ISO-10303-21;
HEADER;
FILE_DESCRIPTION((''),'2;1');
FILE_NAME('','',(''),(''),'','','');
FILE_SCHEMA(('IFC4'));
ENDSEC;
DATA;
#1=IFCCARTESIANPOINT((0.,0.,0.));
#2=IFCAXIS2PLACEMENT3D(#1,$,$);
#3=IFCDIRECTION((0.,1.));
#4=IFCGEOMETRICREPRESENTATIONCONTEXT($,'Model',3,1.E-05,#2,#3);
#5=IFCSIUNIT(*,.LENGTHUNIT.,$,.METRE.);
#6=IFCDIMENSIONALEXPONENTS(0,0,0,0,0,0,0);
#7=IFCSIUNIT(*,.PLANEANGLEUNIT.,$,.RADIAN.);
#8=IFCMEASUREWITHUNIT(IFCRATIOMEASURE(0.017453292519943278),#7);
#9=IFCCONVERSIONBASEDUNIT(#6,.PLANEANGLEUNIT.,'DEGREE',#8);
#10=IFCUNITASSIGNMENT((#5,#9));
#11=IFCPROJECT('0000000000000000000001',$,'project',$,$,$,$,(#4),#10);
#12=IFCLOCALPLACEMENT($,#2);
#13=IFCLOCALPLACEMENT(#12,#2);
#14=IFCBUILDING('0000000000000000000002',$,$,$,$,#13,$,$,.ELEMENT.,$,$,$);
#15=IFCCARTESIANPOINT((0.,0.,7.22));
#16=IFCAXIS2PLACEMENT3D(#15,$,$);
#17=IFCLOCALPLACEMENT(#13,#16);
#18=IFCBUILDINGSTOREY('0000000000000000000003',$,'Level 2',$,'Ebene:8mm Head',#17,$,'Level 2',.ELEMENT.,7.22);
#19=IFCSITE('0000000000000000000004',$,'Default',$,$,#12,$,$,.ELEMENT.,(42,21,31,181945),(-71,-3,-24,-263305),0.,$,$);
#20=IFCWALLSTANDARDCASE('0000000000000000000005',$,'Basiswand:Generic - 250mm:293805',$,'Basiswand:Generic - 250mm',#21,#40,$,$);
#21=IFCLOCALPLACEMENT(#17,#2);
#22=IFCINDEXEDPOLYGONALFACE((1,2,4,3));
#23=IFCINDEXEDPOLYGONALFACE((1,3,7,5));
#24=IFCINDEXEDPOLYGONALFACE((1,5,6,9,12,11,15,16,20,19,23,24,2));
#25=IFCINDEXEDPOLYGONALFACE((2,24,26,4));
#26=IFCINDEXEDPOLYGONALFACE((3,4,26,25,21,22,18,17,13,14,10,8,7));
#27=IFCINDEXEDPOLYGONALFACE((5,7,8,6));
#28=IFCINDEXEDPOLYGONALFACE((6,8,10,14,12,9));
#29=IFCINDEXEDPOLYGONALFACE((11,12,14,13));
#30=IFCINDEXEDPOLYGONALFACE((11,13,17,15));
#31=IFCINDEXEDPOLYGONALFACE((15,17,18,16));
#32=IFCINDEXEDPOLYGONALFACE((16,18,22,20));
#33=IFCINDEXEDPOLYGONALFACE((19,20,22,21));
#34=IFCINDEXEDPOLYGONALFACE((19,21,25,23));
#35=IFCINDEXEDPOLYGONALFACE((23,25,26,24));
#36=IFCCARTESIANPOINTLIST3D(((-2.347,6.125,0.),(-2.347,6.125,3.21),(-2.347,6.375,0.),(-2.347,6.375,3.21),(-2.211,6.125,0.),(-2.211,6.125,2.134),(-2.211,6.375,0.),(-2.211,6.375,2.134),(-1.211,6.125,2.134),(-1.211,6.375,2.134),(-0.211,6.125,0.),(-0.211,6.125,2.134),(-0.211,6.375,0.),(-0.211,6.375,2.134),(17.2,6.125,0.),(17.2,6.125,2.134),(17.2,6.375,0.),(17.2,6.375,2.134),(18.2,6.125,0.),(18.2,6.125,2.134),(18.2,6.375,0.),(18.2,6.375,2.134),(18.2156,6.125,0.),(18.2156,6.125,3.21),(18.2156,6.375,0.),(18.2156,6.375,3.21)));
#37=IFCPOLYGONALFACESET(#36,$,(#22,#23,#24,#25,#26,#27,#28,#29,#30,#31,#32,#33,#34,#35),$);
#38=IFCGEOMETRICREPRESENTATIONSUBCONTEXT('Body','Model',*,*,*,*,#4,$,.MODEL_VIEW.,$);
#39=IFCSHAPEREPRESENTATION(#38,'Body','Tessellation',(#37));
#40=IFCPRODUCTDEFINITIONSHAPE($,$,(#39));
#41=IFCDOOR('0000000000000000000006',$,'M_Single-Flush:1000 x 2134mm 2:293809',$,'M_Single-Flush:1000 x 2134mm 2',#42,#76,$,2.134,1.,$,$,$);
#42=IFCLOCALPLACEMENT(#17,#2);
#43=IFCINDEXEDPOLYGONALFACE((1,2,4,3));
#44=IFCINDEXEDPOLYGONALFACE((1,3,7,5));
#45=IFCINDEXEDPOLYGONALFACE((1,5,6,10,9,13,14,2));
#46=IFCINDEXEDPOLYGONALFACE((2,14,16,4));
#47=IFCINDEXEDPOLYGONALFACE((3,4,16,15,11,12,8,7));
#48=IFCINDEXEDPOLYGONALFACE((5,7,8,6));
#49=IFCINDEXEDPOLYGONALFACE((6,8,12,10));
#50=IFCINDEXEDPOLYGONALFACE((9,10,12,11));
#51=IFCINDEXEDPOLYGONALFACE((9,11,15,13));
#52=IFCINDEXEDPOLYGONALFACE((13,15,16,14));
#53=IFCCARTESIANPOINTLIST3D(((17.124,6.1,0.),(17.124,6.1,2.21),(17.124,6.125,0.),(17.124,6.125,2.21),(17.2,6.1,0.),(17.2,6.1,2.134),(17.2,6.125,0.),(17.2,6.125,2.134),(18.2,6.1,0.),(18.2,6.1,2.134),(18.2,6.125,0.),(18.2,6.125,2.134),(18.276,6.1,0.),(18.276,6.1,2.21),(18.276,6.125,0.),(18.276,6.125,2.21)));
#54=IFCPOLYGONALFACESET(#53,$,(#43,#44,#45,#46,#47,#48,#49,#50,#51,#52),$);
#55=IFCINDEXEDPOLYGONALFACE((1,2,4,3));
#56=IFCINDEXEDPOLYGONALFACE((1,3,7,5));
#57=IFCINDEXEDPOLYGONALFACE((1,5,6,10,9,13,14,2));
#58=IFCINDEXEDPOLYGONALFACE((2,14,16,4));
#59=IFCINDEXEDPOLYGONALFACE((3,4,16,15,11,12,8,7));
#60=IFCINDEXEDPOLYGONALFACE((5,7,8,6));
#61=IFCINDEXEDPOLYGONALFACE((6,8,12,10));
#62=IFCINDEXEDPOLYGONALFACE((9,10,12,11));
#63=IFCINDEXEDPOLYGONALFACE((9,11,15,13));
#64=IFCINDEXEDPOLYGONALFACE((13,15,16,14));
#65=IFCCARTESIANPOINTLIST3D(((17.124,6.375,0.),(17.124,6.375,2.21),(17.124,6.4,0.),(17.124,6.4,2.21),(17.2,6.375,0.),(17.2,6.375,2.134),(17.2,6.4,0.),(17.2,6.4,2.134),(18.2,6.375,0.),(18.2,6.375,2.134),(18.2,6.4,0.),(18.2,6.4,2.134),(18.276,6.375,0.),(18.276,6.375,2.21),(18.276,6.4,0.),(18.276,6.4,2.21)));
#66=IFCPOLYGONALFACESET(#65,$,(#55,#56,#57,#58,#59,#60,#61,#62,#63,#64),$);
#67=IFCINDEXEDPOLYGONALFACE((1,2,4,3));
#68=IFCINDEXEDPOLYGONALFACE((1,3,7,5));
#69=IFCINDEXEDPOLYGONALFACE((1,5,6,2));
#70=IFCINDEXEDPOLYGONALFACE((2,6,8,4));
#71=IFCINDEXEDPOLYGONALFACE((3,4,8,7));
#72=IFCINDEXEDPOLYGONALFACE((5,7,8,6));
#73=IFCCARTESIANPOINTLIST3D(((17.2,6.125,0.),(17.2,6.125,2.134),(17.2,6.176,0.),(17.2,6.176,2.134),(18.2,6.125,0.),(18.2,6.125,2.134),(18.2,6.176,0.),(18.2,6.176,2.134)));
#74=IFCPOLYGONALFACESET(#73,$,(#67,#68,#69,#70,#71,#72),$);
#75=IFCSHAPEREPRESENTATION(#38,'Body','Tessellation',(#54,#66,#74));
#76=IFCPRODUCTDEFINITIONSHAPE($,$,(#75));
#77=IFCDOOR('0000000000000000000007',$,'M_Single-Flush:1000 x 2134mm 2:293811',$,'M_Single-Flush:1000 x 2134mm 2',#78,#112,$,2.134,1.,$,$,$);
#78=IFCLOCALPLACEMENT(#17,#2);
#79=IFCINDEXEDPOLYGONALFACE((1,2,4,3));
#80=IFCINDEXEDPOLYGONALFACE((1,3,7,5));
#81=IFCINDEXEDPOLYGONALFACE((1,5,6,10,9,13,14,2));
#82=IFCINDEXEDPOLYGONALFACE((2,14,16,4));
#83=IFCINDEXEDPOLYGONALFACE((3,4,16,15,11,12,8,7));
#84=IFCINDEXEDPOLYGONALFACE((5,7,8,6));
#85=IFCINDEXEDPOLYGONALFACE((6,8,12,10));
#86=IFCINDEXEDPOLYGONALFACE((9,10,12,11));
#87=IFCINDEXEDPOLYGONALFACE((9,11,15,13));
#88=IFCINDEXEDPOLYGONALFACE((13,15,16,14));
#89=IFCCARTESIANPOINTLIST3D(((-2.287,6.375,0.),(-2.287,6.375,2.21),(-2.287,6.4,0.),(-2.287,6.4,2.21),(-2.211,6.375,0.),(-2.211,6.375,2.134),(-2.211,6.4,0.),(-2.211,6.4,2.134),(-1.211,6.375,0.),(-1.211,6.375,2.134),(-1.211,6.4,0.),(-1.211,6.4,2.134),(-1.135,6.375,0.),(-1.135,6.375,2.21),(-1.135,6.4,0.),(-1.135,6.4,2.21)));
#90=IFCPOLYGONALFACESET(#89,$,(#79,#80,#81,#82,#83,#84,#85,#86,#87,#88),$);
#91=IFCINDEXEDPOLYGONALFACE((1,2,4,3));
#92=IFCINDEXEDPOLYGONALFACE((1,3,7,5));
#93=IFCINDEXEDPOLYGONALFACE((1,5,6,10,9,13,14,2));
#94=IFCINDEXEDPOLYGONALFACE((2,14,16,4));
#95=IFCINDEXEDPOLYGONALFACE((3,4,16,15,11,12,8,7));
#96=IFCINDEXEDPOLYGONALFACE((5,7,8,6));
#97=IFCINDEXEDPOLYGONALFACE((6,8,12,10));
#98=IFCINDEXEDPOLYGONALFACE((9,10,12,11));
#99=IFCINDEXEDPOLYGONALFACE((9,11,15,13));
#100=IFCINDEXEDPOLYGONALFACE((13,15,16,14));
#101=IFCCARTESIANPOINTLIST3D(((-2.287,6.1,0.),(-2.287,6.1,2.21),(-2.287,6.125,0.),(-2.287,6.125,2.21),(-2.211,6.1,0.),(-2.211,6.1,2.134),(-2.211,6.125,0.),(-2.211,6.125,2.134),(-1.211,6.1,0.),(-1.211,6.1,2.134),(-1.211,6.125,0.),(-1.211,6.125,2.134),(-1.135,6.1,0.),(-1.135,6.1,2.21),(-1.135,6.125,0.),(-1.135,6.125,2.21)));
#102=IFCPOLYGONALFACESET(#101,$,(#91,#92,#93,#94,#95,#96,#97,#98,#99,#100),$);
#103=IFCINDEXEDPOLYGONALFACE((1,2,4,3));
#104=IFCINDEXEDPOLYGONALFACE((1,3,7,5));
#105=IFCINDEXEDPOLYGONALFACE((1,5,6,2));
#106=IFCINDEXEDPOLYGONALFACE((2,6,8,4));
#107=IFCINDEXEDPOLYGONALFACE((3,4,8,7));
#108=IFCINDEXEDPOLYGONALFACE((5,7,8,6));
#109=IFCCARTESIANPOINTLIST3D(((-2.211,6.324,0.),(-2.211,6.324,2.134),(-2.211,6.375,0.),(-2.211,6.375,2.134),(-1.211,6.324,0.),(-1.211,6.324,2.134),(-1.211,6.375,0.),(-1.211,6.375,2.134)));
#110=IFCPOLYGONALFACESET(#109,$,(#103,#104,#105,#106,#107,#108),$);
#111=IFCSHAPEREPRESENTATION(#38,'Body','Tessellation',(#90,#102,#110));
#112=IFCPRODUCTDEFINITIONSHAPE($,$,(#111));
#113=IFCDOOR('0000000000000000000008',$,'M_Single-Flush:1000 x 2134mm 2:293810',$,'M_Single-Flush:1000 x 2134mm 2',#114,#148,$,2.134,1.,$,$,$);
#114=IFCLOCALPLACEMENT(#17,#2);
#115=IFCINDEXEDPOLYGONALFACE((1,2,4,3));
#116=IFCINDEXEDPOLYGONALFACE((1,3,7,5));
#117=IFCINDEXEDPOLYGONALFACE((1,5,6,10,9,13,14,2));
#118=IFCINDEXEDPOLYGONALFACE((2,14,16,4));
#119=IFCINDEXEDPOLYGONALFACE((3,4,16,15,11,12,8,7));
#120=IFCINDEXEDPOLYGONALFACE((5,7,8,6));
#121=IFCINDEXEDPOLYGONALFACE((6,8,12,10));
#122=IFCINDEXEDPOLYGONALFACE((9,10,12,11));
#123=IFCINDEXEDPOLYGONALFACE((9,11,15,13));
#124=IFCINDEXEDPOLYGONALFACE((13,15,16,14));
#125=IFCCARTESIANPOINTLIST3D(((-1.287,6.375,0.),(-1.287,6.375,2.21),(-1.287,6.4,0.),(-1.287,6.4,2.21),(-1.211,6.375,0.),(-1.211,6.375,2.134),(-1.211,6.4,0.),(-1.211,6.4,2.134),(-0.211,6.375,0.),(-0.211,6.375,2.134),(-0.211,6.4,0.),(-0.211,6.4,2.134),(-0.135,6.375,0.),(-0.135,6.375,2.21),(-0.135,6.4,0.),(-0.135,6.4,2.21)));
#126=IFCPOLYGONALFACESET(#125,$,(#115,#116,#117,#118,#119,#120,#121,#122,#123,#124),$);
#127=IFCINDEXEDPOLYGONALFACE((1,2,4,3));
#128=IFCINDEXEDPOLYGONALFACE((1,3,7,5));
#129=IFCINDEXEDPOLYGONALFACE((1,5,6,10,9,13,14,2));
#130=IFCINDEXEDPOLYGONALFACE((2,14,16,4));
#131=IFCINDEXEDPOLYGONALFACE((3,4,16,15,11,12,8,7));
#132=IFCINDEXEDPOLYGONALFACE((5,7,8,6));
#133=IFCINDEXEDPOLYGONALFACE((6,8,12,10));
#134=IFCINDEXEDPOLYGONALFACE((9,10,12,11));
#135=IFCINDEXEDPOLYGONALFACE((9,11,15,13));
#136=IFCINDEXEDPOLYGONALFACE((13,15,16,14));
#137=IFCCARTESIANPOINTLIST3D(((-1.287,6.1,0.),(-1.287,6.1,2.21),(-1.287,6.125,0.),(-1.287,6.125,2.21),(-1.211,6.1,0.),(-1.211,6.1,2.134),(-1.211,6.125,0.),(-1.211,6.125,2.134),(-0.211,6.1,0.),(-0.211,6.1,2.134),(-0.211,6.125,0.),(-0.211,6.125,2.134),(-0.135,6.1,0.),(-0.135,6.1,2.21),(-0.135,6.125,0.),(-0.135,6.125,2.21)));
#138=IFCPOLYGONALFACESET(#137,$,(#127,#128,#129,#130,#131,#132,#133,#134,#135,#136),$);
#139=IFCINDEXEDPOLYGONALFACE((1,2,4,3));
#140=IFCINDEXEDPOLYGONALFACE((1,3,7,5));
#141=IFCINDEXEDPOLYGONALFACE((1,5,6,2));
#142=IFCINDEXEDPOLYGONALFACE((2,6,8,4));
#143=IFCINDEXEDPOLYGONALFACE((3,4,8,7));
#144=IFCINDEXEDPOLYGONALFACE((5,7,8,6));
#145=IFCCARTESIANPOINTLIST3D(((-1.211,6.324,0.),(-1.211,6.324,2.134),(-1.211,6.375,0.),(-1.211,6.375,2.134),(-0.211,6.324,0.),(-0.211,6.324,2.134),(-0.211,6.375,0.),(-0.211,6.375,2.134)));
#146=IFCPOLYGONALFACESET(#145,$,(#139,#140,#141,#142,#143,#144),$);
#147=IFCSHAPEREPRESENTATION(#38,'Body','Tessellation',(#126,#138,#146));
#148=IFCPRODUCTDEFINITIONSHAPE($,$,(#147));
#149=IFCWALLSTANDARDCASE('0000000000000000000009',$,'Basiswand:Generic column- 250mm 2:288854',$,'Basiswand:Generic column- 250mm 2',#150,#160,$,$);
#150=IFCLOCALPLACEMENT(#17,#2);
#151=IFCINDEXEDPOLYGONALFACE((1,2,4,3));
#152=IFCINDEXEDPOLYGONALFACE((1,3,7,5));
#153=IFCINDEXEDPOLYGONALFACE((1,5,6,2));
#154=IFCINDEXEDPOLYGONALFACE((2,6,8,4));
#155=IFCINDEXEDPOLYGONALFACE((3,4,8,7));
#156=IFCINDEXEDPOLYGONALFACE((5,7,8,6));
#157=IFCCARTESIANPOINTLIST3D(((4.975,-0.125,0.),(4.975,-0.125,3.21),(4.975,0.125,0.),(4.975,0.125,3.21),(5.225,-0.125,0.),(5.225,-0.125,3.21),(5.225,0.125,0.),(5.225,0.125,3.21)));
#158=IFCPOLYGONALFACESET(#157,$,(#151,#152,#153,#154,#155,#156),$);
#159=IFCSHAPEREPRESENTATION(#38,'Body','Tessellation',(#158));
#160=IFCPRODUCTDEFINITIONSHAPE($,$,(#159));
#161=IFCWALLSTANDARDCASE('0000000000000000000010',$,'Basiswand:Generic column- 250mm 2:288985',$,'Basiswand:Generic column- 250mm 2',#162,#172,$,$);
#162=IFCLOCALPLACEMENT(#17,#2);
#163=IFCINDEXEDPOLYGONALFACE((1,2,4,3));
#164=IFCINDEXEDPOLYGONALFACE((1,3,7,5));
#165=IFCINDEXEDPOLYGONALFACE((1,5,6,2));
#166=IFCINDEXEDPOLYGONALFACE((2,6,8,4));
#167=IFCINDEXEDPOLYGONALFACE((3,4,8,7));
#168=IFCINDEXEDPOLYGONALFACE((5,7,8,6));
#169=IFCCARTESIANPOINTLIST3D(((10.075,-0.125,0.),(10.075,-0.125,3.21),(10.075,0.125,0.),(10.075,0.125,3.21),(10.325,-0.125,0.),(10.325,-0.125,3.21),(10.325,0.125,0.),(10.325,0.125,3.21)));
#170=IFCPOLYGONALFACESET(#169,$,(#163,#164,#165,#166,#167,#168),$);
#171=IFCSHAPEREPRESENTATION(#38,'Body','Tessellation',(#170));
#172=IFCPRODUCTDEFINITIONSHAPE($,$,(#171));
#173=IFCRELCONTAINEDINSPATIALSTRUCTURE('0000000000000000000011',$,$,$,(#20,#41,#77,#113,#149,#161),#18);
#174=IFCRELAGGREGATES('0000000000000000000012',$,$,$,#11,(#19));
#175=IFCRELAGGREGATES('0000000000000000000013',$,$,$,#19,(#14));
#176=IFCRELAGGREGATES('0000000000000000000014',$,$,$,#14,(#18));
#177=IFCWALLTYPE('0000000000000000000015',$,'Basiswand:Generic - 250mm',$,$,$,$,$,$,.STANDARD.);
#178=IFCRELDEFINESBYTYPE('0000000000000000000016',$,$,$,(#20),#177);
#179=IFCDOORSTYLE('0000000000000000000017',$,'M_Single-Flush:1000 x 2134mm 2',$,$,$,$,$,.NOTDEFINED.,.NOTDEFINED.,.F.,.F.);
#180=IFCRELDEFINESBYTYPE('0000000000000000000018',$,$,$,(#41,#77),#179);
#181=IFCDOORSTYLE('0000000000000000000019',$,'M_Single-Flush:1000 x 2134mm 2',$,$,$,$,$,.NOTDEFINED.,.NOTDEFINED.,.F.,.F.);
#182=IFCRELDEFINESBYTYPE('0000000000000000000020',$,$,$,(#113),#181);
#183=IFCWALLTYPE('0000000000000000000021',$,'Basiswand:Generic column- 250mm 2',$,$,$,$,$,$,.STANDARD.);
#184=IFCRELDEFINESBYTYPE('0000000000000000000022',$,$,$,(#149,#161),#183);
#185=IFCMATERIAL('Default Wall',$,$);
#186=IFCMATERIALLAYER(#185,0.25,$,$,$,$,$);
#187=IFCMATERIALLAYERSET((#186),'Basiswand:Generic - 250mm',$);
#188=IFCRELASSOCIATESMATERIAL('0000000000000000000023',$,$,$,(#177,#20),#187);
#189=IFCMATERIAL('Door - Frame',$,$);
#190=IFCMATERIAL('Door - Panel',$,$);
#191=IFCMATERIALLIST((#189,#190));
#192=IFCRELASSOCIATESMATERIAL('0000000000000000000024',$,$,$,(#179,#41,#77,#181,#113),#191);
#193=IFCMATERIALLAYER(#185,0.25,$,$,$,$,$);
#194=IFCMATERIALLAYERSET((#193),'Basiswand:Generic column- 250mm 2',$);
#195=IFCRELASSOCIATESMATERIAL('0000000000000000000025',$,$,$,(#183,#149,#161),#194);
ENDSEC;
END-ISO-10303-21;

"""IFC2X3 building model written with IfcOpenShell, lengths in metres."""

from ifc_helpers import new_model, entity, si_unit, converted_unit, direction, frame, frame_2d, origin, place, context, subcontext, project, spatial, polyline, rectangle, outline, extrude, clip, bounded_halfspace, source, transform, mapped, material, material_list, layer, layer_set, layer_usage, type_object, type_shapes, element, fill, save


model = new_model("IFC2X3")

# Units and contexts
model_context = context("Model", 3, precision=1e-05, world=origin(), true_north=direction((0.0, 1.0)))
body_context = subcontext(model_context, "Body", "Model", "MODEL_VIEW")
ifc_project = project(units=[si_unit("LENGTHUNIT", "METRE"), converted_unit("PLANEANGLEUNIT", "DEGREE", entity("IfcRatioMeasure", 0.017453292519943278), si_unit("PLANEANGLEUNIT", "RADIAN"), dimensions=[0, 0, 0, 0, 0, 0, 0])], contexts=[model_context])

# Site, building, storey
site_placement = place(None, origin())
site = spatial("IfcSite", under=ifc_project, at=site_placement, Name="Default", CompositionType="ELEMENT", RefLatitude=(42, 21, 31, 181945), RefLongitude=(-71, -3, -24, -263305), RefElevation=0.0)
building_placement = place(site_placement, origin())
building = spatial("IfcBuilding", under=site, at=building_placement, CompositionType="ELEMENT")
storey_placement = place(building_placement, frame((0.0, 0.0, 7.22)))
storey = spatial("IfcBuildingStorey", under=building, at=storey_placement, Name="Level 2", ObjectType="Ebene:8mm Head", LongName="Level 2", CompositionType="ELEMENT", Elevation=7.22)

# Shared definitions
ifc_material_1 = material(Name="Default Wall")
ifc_layer_1 = layer(ifc_material_1, 0.25)
ifc_layer_set_1 = layer_set([ifc_layer_1], Name="Basiswand:Generic - 250mm")
ifc_layer_usage_1 = layer_usage(ifc_layer_set_1, "AXIS2", "NEGATIVE", 0.125)
wall_type_1 = type_object("IfcWallType", Name="Basiswand:Generic - 250mm", PredefinedType="STANDARD", material=ifc_layer_set_1)
ifc_material_2 = material(Name="Door - Frame")
ifc_material_3 = material(Name="Door - Panel")
ifc_material_list_1 = material_list([ifc_material_2, ifc_material_3])
door_style_1 = type_object("IfcDoorStyle", Name="M_Single-Flush:1000 x 2134mm 2", ConstructionType="NOTDEFINED", OperationType="NOTDEFINED", ParameterTakesPrecedence=False, Sizeable=False, material=ifc_material_list_1)
shared_shape_1 = source(origin(), body_context, "Body", "SweptSolid", [
    extrude(outline(polyline([(-0.576, -1.124), (0.576, -1.124), (0.576, 1.086), (0.5, 1.086), (0.5, -1.048), (-0.5, -1.048), (-0.5, 1.086), (-0.576, 1.086), (-0.576, -1.124)])), frame((0.5, 0.275, 1.086), z_axis=(0.0, -1.0, 0.0), x_axis=(-1.0, 0.0, 0.0)), (0.0, 0.0, 1.0), 0.025),
    extrude(outline(polyline([(-1.124, -0.576), (1.086, -0.576), (1.086, -0.5), (-1.048, -0.5), (-1.048, 0.5), (1.086, 0.5), (1.086, 0.576), (-1.124, 0.576), (-1.124, -0.576)])), frame((0.5, 0.0, 1.086), z_axis=(0.0, -1.0, 0.0), x_axis=(0.0, 0.0, -1.0)), (0.0, 0.0, 1.0), 0.025),
    extrude(rectangle(XDim=1.0, YDim=0.051, at=frame_2d((0.0, 0.0), x_axis=(1.0, 0.0))), frame((0.5, 0.2245, 0.0)), (0.0, 0.0, 1.0), 2.134),
])
type_shapes(door_style_1, [shared_shape_1])

# Wall, openings, doors
wall_1_placement = place(storey_placement, frame((18.2156, 6.25, 0.0), z_axis=(0.0, 0.0, 1.0), x_axis=(-1.0, 0.0, 0.0)))
wall_1 = element("IfcWallStandardCase", 1, at=wall_1_placement, inside=storey, type_object=wall_type_1, material=ifc_layer_usage_1, Name="Basiswand:Generic - 250mm:293805", ObjectType="Basiswand:Generic - 250mm", context=body_context, shape_type="Clipping", body=[
    clip(extrude(rectangle(XDim=0.25, YDim=20.5626, at=frame_2d((10.2813, 0.0), x_axis=(0.0, -1.0))), origin(), (0.0, 0.0, 1.0), 3.21), bounded_halfspace(frame((0.0, 0.125, 3.21), z_axis=(0.0, 0.0, -1.0), x_axis=(0.0, -1.0, 0.0)), True, frame((0.0, 0.125, 3.21)), polyline([(0.0, 0.0), (0.0, -0.25), (20.5626, -0.25), (20.5626, 0.0), (15.6516, 0.0), (1.2897, 0.0), (0.0, 0.0)]))),
])
opening_1_placement = place(wall_1_placement, frame((0.0156, -0.125, 0.0)))
opening_1 = element("IfcOpeningElement", 2, at=opening_1_placement, cuts=wall_1, ObjectType="Opening", context=body_context, shape_type="SweptSolid", body=[
    extrude(rectangle(XDim=1.0, YDim=2.134, at=frame_2d((1.067, 0.5), x_axis=(0.0, -1.0))), frame((0.0, 0.0, 0.0), z_axis=(0.0, 1.0, 0.0), x_axis=(0.0, 0.0, 1.0)), (0.0, 0.0, 1.0), 0.25),
])
opening_2_placement = place(wall_1_placement, frame((19.4266, 0.125, 0.0)))
opening_2 = element("IfcOpeningElement", 3, at=opening_2_placement, cuts=wall_1, ObjectType="Opening", context=body_context, shape_type="SweptSolid", body=[
    extrude(rectangle(XDim=1.0, YDim=2.134, at=frame_2d((1.067, 0.5), x_axis=(0.0, 1.0))), frame((0.0, 0.0, 0.0), z_axis=(0.0, -1.0, 0.0), x_axis=(0.0, 0.0, 1.0)), (0.0, 0.0, 1.0), 0.25),
])
opening_3_placement = place(wall_1_placement, frame((20.4266, 0.125, 0.0)))
opening_3 = element("IfcOpeningElement", 4, at=opening_3_placement, cuts=wall_1, ObjectType="Opening", context=body_context, shape_type="SweptSolid", body=[
    extrude(rectangle(XDim=1.0, YDim=2.134, at=frame_2d((1.067, 0.5), x_axis=(0.0, -1.0))), frame((0.0, 0.0, 0.0), z_axis=(0.0, -1.0, 0.0), x_axis=(0.0, 0.0, 1.0)), (0.0, 0.0, 1.0), 0.25),
])
door_1_placement = place(opening_1_placement, origin())
door_1 = element("IfcDoor", 5, at=door_1_placement, inside=storey, type_object=door_style_1, material=ifc_material_list_1, Name="M_Single-Flush:1000 x 2134mm 2:293809", ObjectType="M_Single-Flush:1000 x 2134mm 2", OverallHeight=2.134, OverallWidth=1.0, context=body_context, shape_type="MappedRepresentation", body=[
    mapped(shared_shape_1, transform((0.0, 0.0, 0.0), scale=1.0)),
])
fill(opening_1, door_1)
door_2_placement = place(opening_3_placement, frame((0.0, 0.0, 0.0), z_axis=(0.0, 0.0, 1.0), x_axis=(-1.0, 0.0, 0.0)))
door_2 = element("IfcDoor", 6, at=door_2_placement, inside=storey, type_object=door_style_1, material=ifc_material_list_1, Name="M_Single-Flush:1000 x 2134mm 2:293811", ObjectType="M_Single-Flush:1000 x 2134mm 2", OverallHeight=2.134, OverallWidth=1.0, context=body_context, shape_type="MappedRepresentation", body=[
    mapped(shared_shape_1, transform((0.0, 0.0, 0.0), scale=1.0)),
])
fill(opening_3, door_2)
door_style_2 = type_object("IfcDoorStyle", Name="M_Single-Flush:1000 x 2134mm 2", ConstructionType="NOTDEFINED", OperationType="NOTDEFINED", ParameterTakesPrecedence=False, Sizeable=False, material=ifc_material_list_1)
shared_shape_2 = source(origin(), body_context, "Body", "SweptSolid", [
    extrude(outline(polyline([(-0.576, -1.124), (0.576, -1.124), (0.576, 1.086), (0.5, 1.086), (0.5, -1.048), (-0.5, -1.048), (-0.5, 1.086), (-0.576, 1.086), (-0.576, -1.124)])), frame((0.5, 0.25, 1.086), z_axis=(0.0, 1.0, 0.0), x_axis=(1.0, 0.0, 0.0)), (0.0, 0.0, 1.0), 0.025),
    extrude(outline(polyline([(-1.124, -0.576), (1.086, -0.576), (1.086, -0.5), (-1.048, -0.5), (-1.048, 0.5), (1.086, 0.5), (1.086, 0.576), (-1.124, 0.576), (-1.124, -0.576)])), frame((0.5, -0.025, 1.086), z_axis=(0.0, 1.0, 0.0), x_axis=(0.0, 0.0, -1.0)), (0.0, 0.0, 1.0), 0.025),
    extrude(rectangle(XDim=0.051, YDim=1.0, at=frame_2d((0.0, 0.0), x_axis=(1.0, 0.0))), frame((0.5, 0.2245, 0.0), z_axis=(0.0, 0.0, 1.0), x_axis=(0.0, 1.0, 0.0)), (0.0, 0.0, 1.0), 2.134),
])
type_shapes(door_style_2, [shared_shape_2])
door_3_placement = place(opening_2_placement, frame((0.0, 0.0, 0.0), z_axis=(0.0, 0.0, 1.0), x_axis=(-1.0, 0.0, 0.0)))
door_3 = element("IfcDoor", 7, at=door_3_placement, inside=storey, type_object=door_style_2, material=ifc_material_list_1, Name="M_Single-Flush:1000 x 2134mm 2:293810", ObjectType="M_Single-Flush:1000 x 2134mm 2", OverallHeight=2.134, OverallWidth=1.0, context=body_context, shape_type="MappedRepresentation", body=[
    mapped(shared_shape_2, transform((0.0, 0.0, 0.0), scale=1.0)),
])
fill(opening_2, door_3)

# Walls
ifc_layer_2 = layer(ifc_material_1, 0.25)
ifc_layer_set_2 = layer_set([ifc_layer_2], Name="Basiswand:Generic column- 250mm 2")
ifc_layer_usage_2 = layer_usage(ifc_layer_set_2, "AXIS2", "NEGATIVE", 0.125)
wall_type_2 = type_object("IfcWallType", Name="Basiswand:Generic column- 250mm 2", PredefinedType="STANDARD", material=ifc_layer_set_2)
for number, where, name in (
    (8, (4.975, 0.0, 0.0), "Basiswand:Generic column- 250mm 2:288854"),
    (9, (10.075, 0.0, 0.0), "Basiswand:Generic column- 250mm 2:288985"),
):
    element("IfcWallStandardCase", number, at=place(storey_placement, frame(where)), inside=storey, type_object=wall_type_2, material=ifc_layer_usage_2, Name=name, ObjectType="Basiswand:Generic column- 250mm 2", context=body_context, shape_type="Clipping", body=[
        clip(extrude(rectangle(XDim=0.25, YDim=0.25, at=frame_2d((0.125, 0.0), x_axis=(-1.0, 0.0))), origin(), (0.0, 0.0, 1.0), 3.21), bounded_halfspace(frame((0.0, -0.125, 3.21), z_axis=(0.0, 0.0, -1.0), x_axis=(0.0, 1.0, 0.0)), True, frame((0.0, -0.125, 3.21), z_axis=(0.0, 0.0, -1.0), x_axis=(0.0, 1.0, 0.0)), polyline([(0.0, 0.0), (0.25, 0.0), (0.25, 0.25), (0.0, 0.25), (0.0, 0.0)]))),
    ])

save(model, "model.ifc")
